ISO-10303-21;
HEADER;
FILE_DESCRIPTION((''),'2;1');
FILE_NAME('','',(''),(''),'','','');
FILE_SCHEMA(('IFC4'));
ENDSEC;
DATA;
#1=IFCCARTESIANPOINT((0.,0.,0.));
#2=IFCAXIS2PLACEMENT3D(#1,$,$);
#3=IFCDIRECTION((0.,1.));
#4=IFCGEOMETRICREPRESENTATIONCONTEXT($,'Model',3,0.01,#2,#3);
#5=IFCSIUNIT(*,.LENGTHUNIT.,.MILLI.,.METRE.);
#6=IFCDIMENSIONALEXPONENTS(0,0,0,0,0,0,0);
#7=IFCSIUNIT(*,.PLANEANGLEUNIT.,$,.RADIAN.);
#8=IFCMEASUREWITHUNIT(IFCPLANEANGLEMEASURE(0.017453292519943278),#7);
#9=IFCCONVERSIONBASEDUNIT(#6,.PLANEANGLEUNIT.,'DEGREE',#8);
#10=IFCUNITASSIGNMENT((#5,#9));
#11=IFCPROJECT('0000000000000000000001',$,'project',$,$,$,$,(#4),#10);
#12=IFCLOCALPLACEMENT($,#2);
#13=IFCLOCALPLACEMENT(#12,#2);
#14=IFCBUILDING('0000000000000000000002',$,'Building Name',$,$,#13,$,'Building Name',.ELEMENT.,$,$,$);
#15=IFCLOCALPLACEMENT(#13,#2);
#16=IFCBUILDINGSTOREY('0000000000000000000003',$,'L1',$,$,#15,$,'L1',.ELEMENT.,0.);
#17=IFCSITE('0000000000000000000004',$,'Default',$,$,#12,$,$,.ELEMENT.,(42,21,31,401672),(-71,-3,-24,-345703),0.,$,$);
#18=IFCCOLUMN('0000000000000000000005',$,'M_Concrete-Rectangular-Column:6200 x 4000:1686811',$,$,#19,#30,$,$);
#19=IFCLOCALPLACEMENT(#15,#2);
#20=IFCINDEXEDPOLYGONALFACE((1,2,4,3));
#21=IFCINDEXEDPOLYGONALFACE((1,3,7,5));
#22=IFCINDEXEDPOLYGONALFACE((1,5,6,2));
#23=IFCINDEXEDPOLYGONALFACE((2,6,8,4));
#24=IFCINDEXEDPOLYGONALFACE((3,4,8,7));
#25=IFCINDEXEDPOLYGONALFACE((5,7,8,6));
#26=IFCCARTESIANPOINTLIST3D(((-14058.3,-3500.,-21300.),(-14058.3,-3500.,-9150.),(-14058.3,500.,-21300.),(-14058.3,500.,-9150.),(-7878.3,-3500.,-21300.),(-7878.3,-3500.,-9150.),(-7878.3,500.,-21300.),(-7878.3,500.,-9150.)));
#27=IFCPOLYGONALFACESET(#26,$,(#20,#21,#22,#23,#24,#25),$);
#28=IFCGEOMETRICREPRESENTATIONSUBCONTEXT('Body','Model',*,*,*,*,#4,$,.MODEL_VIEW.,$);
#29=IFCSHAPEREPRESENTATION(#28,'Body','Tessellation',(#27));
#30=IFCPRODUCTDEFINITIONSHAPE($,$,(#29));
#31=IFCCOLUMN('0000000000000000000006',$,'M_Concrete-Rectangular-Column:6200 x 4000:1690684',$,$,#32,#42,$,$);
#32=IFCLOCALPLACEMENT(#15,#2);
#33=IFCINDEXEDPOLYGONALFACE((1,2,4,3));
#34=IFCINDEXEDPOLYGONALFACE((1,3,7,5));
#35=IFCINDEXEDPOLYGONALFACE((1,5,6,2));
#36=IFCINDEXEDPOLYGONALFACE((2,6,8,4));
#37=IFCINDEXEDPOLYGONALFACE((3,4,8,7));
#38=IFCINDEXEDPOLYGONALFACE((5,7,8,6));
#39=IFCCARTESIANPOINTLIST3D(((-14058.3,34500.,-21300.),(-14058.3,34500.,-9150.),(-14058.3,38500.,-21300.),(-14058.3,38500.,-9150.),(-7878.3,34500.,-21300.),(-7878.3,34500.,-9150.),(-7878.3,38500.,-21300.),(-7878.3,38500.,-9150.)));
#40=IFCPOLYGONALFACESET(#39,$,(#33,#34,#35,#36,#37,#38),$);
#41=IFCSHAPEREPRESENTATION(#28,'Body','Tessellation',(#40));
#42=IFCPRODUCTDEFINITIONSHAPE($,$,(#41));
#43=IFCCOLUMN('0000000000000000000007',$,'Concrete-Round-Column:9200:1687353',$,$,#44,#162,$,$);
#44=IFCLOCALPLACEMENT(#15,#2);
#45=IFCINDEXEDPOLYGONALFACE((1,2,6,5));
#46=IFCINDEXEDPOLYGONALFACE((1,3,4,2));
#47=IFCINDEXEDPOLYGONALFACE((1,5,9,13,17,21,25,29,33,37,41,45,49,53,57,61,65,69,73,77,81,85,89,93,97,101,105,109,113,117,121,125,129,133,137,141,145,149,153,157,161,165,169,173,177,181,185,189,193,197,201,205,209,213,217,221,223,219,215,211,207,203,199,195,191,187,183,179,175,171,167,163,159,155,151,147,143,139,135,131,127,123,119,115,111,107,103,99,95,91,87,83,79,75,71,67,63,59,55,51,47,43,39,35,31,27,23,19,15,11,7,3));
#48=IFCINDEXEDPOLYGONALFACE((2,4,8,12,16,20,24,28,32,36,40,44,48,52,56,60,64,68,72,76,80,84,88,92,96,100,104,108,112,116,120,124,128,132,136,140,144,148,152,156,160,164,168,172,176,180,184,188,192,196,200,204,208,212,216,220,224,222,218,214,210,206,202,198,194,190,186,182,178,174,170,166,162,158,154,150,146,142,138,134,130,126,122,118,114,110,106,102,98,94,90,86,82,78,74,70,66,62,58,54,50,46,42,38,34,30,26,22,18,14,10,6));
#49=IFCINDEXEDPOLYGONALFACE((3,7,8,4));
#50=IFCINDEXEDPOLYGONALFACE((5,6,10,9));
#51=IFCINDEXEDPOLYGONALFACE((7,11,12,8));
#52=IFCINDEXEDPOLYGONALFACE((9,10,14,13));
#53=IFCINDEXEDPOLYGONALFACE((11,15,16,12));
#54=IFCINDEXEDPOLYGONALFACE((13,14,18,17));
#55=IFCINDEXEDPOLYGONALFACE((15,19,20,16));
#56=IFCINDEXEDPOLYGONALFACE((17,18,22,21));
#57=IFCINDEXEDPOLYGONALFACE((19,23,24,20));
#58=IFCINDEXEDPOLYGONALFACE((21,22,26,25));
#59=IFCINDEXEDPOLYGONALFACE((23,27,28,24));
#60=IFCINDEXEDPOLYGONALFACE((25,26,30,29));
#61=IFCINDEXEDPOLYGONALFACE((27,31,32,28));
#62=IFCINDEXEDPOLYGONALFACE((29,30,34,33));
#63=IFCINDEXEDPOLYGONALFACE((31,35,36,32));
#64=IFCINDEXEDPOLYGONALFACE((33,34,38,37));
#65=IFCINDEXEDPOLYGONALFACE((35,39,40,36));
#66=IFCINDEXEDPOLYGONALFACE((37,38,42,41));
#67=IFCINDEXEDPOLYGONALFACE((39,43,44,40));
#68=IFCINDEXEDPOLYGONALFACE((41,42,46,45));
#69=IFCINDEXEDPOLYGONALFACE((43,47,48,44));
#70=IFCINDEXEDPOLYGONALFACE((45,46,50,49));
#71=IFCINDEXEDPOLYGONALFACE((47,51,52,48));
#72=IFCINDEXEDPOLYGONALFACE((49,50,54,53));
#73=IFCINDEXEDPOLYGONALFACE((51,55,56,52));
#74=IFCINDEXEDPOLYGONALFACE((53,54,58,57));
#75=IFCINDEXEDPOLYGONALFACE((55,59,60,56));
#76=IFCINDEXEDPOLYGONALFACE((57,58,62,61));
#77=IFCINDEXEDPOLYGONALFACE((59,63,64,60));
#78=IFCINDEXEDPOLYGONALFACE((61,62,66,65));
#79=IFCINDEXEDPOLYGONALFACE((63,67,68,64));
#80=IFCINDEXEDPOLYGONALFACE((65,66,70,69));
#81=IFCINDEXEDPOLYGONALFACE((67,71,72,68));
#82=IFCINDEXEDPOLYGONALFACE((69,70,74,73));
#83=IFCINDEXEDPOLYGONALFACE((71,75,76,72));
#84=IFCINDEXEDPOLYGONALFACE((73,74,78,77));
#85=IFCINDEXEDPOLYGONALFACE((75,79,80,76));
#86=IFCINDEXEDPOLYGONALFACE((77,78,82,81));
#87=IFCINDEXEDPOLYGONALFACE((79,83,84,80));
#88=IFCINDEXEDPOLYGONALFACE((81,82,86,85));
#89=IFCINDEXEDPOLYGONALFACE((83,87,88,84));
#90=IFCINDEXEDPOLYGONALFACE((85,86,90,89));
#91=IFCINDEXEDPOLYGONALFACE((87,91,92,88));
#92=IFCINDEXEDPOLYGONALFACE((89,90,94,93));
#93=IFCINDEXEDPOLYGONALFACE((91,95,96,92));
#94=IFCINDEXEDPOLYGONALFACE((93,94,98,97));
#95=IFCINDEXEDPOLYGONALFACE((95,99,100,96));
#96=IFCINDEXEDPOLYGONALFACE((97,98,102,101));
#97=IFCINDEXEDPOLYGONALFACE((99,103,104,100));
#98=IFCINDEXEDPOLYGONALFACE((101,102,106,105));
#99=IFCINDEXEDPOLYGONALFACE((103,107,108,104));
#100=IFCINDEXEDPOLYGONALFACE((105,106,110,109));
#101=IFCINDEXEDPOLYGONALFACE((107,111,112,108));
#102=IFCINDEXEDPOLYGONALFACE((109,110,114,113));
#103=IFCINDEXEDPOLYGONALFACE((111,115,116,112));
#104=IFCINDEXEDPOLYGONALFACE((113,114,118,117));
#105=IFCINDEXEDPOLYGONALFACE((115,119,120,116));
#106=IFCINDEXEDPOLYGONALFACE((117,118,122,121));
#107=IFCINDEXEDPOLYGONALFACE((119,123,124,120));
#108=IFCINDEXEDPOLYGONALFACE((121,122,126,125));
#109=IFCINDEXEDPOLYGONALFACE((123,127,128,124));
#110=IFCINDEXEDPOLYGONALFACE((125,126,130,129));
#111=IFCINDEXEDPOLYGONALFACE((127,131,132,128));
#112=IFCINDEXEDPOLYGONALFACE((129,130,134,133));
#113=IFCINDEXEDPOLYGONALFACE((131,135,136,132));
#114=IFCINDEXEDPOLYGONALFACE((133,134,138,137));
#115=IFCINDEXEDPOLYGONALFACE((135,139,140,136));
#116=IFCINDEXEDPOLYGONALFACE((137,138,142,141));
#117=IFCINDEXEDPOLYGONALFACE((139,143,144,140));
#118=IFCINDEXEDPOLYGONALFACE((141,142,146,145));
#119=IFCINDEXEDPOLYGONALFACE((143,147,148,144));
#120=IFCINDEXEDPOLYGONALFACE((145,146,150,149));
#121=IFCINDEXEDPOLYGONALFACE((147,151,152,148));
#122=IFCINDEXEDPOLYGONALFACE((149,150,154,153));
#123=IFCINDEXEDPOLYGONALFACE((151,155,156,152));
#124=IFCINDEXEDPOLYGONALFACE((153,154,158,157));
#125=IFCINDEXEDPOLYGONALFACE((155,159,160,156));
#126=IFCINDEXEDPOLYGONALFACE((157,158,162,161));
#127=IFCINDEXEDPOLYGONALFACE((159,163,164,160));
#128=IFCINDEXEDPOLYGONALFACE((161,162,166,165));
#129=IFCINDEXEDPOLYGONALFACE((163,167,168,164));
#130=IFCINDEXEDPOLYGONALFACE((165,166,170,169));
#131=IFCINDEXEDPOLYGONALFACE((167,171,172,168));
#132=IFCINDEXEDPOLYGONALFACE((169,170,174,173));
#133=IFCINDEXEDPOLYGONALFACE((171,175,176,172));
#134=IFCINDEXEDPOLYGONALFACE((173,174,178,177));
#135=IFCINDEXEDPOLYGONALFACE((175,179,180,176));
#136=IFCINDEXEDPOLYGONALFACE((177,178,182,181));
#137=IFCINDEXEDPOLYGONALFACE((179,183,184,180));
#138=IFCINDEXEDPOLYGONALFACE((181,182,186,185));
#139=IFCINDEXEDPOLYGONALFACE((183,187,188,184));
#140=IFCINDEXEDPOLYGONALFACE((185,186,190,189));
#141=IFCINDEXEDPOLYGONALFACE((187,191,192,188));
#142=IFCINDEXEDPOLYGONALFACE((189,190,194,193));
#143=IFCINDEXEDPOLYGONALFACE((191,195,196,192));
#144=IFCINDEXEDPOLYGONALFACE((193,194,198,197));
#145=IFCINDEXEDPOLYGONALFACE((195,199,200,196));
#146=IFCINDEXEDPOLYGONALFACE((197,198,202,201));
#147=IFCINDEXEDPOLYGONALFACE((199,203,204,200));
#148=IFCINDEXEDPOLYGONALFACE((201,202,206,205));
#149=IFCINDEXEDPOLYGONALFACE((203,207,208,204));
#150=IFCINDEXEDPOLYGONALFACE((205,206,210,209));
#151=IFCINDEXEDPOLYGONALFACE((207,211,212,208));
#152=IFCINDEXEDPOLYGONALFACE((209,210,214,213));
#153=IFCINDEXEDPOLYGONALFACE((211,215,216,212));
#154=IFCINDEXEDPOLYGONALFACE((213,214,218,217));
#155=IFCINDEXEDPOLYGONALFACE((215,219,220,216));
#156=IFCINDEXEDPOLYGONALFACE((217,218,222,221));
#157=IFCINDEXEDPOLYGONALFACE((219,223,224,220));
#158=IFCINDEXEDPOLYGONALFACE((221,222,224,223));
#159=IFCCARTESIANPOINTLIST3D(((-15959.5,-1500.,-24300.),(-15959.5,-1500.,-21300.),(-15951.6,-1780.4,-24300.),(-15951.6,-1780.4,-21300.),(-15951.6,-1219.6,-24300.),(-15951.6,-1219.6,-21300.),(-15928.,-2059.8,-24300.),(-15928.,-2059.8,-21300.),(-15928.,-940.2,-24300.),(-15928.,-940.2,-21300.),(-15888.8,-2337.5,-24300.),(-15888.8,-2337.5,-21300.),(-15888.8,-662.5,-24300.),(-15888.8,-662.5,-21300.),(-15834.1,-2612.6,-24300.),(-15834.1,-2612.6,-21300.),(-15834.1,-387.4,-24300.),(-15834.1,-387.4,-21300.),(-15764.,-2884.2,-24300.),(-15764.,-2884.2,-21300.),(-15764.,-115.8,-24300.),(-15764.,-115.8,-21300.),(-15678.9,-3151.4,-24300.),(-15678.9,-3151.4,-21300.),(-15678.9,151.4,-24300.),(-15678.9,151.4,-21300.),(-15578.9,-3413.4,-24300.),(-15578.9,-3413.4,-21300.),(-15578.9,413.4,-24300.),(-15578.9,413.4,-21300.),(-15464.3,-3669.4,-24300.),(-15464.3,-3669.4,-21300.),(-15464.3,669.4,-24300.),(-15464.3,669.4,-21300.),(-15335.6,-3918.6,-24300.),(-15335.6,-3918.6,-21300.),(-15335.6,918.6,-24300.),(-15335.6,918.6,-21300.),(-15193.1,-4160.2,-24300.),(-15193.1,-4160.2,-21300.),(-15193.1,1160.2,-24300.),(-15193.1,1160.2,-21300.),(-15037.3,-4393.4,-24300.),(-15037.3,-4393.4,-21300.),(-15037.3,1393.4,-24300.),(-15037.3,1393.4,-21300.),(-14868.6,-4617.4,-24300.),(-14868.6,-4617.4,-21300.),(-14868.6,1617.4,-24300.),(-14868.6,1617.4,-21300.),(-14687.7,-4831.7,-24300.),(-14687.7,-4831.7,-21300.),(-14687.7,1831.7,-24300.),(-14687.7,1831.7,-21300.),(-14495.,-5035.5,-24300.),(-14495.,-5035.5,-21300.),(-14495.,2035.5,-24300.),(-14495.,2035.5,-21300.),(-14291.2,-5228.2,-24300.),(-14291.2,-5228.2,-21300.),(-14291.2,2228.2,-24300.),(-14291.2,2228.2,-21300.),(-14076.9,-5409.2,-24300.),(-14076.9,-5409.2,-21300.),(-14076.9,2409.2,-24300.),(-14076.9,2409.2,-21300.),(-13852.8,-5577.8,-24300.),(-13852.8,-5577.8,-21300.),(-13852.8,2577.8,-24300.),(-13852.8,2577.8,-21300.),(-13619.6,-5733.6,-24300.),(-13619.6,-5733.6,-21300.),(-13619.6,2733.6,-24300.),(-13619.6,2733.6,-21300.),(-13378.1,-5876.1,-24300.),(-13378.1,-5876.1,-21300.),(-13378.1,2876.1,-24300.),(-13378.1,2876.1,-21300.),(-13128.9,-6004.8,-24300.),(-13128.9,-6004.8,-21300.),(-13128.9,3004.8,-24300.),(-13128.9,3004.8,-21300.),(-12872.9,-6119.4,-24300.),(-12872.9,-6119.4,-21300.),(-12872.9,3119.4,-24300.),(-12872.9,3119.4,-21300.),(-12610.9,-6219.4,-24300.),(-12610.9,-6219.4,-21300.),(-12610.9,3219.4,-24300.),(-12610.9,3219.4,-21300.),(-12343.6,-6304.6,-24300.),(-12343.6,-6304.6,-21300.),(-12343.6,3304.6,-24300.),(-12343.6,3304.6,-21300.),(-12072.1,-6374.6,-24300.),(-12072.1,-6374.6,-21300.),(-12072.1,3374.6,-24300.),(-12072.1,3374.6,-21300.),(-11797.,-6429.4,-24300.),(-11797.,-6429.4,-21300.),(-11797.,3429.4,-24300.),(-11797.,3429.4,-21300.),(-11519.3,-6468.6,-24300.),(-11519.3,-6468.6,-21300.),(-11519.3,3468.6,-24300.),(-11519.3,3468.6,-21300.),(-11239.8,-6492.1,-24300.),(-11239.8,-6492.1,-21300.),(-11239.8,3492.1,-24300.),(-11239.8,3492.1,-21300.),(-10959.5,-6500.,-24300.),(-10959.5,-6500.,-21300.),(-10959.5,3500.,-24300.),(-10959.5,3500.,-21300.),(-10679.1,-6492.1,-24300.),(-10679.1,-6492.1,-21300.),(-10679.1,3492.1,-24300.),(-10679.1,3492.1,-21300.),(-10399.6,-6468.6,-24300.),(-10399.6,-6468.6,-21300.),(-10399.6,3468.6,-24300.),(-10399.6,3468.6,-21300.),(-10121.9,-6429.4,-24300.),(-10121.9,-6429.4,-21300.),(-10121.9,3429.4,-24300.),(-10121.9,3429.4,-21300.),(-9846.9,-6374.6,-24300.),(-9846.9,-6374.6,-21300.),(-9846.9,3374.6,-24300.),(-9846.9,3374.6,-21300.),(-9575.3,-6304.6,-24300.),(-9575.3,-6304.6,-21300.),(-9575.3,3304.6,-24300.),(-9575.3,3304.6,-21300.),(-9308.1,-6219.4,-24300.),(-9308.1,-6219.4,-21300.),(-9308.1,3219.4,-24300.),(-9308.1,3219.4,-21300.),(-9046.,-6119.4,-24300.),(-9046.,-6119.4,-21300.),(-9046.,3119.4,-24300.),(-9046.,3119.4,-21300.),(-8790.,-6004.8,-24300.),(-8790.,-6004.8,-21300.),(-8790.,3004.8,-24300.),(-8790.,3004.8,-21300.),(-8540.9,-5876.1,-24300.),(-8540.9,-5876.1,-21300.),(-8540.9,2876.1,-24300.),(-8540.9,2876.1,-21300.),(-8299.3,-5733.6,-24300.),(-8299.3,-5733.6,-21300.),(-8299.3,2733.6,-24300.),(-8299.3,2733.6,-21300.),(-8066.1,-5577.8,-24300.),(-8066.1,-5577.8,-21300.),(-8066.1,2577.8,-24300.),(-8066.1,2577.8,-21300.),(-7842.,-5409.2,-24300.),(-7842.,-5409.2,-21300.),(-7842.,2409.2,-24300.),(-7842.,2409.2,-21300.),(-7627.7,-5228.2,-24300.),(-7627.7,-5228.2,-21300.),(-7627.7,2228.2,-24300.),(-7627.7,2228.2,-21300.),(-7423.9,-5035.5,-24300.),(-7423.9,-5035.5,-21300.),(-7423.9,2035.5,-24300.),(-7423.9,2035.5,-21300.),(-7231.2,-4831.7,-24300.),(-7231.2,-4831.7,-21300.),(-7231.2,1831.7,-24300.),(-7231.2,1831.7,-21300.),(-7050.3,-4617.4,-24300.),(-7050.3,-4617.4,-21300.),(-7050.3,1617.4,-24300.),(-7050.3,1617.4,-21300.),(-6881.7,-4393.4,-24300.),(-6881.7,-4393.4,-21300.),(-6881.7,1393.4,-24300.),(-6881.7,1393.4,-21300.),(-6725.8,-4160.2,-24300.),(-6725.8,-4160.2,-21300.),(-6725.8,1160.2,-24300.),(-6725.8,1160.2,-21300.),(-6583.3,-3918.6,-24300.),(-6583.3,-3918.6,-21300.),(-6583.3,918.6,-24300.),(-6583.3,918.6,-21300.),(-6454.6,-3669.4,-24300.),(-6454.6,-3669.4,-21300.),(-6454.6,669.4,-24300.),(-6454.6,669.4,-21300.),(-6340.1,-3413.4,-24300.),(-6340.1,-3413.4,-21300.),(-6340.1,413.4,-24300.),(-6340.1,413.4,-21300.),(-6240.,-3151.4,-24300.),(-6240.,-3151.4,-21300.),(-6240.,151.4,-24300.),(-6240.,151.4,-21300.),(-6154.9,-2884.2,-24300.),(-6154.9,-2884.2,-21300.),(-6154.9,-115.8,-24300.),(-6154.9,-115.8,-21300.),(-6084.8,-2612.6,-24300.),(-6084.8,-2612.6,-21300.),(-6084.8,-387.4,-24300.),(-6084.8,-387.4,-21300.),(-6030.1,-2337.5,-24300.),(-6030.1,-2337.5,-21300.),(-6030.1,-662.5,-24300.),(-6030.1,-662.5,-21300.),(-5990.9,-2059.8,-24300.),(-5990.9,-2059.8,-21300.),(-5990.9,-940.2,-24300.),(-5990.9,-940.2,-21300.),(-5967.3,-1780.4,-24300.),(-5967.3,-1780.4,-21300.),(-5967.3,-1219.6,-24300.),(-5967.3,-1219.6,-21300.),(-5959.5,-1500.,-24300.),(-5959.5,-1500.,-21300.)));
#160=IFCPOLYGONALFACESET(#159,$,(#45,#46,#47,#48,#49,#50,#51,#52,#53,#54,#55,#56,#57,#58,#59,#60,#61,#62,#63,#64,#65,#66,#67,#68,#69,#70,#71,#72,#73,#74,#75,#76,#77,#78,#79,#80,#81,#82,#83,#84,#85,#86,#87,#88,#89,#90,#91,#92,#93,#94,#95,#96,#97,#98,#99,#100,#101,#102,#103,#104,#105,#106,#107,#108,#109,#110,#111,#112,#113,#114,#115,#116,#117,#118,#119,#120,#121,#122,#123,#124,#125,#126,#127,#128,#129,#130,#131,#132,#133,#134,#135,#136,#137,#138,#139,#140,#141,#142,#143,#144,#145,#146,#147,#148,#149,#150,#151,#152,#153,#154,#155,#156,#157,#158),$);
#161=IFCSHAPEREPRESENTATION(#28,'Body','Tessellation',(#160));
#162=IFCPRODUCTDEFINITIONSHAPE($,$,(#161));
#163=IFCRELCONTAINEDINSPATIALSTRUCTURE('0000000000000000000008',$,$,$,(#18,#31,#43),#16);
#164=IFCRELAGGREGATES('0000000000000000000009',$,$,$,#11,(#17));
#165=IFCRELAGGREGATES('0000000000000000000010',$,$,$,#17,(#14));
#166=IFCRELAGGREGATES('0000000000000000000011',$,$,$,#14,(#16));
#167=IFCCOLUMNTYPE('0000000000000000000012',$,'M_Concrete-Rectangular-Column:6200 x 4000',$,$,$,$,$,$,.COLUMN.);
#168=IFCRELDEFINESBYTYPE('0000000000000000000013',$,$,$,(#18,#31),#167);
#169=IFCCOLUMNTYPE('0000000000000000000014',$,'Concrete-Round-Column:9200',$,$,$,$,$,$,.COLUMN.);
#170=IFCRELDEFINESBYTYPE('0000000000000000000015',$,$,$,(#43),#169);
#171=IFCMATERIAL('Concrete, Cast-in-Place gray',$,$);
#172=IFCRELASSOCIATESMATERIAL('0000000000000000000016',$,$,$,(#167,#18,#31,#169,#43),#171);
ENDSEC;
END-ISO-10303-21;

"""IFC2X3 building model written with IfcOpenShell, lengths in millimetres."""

from ifc_helpers import new_model, entity, si_unit, converted_unit, direction, frame, frame_2d, origin, origin_2d_with_axis, place, context, subcontext, project, spatial, rectangle, circle, extrude, source, transform, mapped, material, type_object, type_shapes, element, save


model = new_model("IFC2X3")

# Units and contexts
model_context = context("Model", 3, precision=0.01, world=origin(), true_north=direction((0.0, 1.0)))
body_context = subcontext(model_context, "Body", "Model", "MODEL_VIEW")
ifc_project = project(units=[si_unit("LENGTHUNIT", "METRE", prefix="MILLI"), converted_unit("PLANEANGLEUNIT", "DEGREE", entity("IfcPlaneAngleMeasure", 0.017453292519943278), si_unit("PLANEANGLEUNIT", "RADIAN"), dimensions=[0, 0, 0, 0, 0, 0, 0])], contexts=[model_context])

# Site, building, storey
site_placement = place(None, origin())
site = spatial("IfcSite", under=ifc_project, at=site_placement, Name="Default", CompositionType="ELEMENT", RefLatitude=(42, 21, 31, 401672), RefLongitude=(-71, -3, -24, -345703), RefElevation=0.0)
building_placement = place(site_placement, origin())
building = spatial("IfcBuilding", under=site, at=building_placement, Name="Building Name", LongName="Building Name", CompositionType="ELEMENT")
storey_placement = place(building_placement, origin())
storey = spatial("IfcBuildingStorey", under=building, at=storey_placement, Name="L1", LongName="L1", CompositionType="ELEMENT", Elevation=0.0)

# Columns
ifc_material_1 = material(Name="Concrete, Cast-in-Place gray")
column_type_1 = type_object("IfcColumnType", Name="M_Concrete-Rectangular-Column:6200 x 4000", PredefinedType="COLUMN", material=ifc_material_1)
shared_shape_1 = source(origin(), body_context, "Body", "SweptSolid", [
    extrude(rectangle(XDim=6180.0, YDim=4000.0, at=origin_2d_with_axis()), frame((0.0, 0.0, -21300.0), z_axis=(0.0, 0.0, 1.0), x_axis=(-1.0, 0.0, 0.0)), (0.0, 0.0, 1.0), 12150.0),
])
type_shapes(column_type_1, [shared_shape_1])
for number, where, name in (
    (1, (-10968.3, -1500.0, 0.0), "M_Concrete-Rectangular-Column:6200 x 4000:1686811"),
    (2, (-10968.3, 36500.0, 0.0), "M_Concrete-Rectangular-Column:6200 x 4000:1690684"),
):
    element("IfcColumn", number, at=place(storey_placement, frame(where)), inside=storey, type_object=column_type_1, material=ifc_material_1, Name=name, context=body_context, shape_type="MappedRepresentation", body=[
        mapped(shared_shape_1, transform((0.0, 0.0, 0.0), scale=1.0)),
    ])
column_type_2 = type_object("IfcColumnType", Name="Concrete-Round-Column:9200", PredefinedType="COLUMN", material=ifc_material_1)
shared_shape_2 = source(origin(), body_context, "Body", "SweptSolid", [
    extrude(circle(Radius=5000.0, at=frame_2d((0.0, 0.0), x_axis=(1.0, 0.0))), frame((0.0, 0.0, -24300.0)), (0.0, 0.0, 1.0), 3000.0),
])
type_shapes(column_type_2, [shared_shape_2])
for number, where, name in (
    (3, (-10959.5, -1500.0, 0.0), "Concrete-Round-Column:9200:1687353"),
):
    element("IfcColumn", number, at=place(storey_placement, frame(where)), inside=storey, type_object=column_type_2, material=ifc_material_1, Name=name, context=body_context, shape_type="MappedRepresentation", body=[
        mapped(shared_shape_2, transform((0.0, 0.0, 0.0), scale=1.0)),
    ])

save(model, "model.ifc")
